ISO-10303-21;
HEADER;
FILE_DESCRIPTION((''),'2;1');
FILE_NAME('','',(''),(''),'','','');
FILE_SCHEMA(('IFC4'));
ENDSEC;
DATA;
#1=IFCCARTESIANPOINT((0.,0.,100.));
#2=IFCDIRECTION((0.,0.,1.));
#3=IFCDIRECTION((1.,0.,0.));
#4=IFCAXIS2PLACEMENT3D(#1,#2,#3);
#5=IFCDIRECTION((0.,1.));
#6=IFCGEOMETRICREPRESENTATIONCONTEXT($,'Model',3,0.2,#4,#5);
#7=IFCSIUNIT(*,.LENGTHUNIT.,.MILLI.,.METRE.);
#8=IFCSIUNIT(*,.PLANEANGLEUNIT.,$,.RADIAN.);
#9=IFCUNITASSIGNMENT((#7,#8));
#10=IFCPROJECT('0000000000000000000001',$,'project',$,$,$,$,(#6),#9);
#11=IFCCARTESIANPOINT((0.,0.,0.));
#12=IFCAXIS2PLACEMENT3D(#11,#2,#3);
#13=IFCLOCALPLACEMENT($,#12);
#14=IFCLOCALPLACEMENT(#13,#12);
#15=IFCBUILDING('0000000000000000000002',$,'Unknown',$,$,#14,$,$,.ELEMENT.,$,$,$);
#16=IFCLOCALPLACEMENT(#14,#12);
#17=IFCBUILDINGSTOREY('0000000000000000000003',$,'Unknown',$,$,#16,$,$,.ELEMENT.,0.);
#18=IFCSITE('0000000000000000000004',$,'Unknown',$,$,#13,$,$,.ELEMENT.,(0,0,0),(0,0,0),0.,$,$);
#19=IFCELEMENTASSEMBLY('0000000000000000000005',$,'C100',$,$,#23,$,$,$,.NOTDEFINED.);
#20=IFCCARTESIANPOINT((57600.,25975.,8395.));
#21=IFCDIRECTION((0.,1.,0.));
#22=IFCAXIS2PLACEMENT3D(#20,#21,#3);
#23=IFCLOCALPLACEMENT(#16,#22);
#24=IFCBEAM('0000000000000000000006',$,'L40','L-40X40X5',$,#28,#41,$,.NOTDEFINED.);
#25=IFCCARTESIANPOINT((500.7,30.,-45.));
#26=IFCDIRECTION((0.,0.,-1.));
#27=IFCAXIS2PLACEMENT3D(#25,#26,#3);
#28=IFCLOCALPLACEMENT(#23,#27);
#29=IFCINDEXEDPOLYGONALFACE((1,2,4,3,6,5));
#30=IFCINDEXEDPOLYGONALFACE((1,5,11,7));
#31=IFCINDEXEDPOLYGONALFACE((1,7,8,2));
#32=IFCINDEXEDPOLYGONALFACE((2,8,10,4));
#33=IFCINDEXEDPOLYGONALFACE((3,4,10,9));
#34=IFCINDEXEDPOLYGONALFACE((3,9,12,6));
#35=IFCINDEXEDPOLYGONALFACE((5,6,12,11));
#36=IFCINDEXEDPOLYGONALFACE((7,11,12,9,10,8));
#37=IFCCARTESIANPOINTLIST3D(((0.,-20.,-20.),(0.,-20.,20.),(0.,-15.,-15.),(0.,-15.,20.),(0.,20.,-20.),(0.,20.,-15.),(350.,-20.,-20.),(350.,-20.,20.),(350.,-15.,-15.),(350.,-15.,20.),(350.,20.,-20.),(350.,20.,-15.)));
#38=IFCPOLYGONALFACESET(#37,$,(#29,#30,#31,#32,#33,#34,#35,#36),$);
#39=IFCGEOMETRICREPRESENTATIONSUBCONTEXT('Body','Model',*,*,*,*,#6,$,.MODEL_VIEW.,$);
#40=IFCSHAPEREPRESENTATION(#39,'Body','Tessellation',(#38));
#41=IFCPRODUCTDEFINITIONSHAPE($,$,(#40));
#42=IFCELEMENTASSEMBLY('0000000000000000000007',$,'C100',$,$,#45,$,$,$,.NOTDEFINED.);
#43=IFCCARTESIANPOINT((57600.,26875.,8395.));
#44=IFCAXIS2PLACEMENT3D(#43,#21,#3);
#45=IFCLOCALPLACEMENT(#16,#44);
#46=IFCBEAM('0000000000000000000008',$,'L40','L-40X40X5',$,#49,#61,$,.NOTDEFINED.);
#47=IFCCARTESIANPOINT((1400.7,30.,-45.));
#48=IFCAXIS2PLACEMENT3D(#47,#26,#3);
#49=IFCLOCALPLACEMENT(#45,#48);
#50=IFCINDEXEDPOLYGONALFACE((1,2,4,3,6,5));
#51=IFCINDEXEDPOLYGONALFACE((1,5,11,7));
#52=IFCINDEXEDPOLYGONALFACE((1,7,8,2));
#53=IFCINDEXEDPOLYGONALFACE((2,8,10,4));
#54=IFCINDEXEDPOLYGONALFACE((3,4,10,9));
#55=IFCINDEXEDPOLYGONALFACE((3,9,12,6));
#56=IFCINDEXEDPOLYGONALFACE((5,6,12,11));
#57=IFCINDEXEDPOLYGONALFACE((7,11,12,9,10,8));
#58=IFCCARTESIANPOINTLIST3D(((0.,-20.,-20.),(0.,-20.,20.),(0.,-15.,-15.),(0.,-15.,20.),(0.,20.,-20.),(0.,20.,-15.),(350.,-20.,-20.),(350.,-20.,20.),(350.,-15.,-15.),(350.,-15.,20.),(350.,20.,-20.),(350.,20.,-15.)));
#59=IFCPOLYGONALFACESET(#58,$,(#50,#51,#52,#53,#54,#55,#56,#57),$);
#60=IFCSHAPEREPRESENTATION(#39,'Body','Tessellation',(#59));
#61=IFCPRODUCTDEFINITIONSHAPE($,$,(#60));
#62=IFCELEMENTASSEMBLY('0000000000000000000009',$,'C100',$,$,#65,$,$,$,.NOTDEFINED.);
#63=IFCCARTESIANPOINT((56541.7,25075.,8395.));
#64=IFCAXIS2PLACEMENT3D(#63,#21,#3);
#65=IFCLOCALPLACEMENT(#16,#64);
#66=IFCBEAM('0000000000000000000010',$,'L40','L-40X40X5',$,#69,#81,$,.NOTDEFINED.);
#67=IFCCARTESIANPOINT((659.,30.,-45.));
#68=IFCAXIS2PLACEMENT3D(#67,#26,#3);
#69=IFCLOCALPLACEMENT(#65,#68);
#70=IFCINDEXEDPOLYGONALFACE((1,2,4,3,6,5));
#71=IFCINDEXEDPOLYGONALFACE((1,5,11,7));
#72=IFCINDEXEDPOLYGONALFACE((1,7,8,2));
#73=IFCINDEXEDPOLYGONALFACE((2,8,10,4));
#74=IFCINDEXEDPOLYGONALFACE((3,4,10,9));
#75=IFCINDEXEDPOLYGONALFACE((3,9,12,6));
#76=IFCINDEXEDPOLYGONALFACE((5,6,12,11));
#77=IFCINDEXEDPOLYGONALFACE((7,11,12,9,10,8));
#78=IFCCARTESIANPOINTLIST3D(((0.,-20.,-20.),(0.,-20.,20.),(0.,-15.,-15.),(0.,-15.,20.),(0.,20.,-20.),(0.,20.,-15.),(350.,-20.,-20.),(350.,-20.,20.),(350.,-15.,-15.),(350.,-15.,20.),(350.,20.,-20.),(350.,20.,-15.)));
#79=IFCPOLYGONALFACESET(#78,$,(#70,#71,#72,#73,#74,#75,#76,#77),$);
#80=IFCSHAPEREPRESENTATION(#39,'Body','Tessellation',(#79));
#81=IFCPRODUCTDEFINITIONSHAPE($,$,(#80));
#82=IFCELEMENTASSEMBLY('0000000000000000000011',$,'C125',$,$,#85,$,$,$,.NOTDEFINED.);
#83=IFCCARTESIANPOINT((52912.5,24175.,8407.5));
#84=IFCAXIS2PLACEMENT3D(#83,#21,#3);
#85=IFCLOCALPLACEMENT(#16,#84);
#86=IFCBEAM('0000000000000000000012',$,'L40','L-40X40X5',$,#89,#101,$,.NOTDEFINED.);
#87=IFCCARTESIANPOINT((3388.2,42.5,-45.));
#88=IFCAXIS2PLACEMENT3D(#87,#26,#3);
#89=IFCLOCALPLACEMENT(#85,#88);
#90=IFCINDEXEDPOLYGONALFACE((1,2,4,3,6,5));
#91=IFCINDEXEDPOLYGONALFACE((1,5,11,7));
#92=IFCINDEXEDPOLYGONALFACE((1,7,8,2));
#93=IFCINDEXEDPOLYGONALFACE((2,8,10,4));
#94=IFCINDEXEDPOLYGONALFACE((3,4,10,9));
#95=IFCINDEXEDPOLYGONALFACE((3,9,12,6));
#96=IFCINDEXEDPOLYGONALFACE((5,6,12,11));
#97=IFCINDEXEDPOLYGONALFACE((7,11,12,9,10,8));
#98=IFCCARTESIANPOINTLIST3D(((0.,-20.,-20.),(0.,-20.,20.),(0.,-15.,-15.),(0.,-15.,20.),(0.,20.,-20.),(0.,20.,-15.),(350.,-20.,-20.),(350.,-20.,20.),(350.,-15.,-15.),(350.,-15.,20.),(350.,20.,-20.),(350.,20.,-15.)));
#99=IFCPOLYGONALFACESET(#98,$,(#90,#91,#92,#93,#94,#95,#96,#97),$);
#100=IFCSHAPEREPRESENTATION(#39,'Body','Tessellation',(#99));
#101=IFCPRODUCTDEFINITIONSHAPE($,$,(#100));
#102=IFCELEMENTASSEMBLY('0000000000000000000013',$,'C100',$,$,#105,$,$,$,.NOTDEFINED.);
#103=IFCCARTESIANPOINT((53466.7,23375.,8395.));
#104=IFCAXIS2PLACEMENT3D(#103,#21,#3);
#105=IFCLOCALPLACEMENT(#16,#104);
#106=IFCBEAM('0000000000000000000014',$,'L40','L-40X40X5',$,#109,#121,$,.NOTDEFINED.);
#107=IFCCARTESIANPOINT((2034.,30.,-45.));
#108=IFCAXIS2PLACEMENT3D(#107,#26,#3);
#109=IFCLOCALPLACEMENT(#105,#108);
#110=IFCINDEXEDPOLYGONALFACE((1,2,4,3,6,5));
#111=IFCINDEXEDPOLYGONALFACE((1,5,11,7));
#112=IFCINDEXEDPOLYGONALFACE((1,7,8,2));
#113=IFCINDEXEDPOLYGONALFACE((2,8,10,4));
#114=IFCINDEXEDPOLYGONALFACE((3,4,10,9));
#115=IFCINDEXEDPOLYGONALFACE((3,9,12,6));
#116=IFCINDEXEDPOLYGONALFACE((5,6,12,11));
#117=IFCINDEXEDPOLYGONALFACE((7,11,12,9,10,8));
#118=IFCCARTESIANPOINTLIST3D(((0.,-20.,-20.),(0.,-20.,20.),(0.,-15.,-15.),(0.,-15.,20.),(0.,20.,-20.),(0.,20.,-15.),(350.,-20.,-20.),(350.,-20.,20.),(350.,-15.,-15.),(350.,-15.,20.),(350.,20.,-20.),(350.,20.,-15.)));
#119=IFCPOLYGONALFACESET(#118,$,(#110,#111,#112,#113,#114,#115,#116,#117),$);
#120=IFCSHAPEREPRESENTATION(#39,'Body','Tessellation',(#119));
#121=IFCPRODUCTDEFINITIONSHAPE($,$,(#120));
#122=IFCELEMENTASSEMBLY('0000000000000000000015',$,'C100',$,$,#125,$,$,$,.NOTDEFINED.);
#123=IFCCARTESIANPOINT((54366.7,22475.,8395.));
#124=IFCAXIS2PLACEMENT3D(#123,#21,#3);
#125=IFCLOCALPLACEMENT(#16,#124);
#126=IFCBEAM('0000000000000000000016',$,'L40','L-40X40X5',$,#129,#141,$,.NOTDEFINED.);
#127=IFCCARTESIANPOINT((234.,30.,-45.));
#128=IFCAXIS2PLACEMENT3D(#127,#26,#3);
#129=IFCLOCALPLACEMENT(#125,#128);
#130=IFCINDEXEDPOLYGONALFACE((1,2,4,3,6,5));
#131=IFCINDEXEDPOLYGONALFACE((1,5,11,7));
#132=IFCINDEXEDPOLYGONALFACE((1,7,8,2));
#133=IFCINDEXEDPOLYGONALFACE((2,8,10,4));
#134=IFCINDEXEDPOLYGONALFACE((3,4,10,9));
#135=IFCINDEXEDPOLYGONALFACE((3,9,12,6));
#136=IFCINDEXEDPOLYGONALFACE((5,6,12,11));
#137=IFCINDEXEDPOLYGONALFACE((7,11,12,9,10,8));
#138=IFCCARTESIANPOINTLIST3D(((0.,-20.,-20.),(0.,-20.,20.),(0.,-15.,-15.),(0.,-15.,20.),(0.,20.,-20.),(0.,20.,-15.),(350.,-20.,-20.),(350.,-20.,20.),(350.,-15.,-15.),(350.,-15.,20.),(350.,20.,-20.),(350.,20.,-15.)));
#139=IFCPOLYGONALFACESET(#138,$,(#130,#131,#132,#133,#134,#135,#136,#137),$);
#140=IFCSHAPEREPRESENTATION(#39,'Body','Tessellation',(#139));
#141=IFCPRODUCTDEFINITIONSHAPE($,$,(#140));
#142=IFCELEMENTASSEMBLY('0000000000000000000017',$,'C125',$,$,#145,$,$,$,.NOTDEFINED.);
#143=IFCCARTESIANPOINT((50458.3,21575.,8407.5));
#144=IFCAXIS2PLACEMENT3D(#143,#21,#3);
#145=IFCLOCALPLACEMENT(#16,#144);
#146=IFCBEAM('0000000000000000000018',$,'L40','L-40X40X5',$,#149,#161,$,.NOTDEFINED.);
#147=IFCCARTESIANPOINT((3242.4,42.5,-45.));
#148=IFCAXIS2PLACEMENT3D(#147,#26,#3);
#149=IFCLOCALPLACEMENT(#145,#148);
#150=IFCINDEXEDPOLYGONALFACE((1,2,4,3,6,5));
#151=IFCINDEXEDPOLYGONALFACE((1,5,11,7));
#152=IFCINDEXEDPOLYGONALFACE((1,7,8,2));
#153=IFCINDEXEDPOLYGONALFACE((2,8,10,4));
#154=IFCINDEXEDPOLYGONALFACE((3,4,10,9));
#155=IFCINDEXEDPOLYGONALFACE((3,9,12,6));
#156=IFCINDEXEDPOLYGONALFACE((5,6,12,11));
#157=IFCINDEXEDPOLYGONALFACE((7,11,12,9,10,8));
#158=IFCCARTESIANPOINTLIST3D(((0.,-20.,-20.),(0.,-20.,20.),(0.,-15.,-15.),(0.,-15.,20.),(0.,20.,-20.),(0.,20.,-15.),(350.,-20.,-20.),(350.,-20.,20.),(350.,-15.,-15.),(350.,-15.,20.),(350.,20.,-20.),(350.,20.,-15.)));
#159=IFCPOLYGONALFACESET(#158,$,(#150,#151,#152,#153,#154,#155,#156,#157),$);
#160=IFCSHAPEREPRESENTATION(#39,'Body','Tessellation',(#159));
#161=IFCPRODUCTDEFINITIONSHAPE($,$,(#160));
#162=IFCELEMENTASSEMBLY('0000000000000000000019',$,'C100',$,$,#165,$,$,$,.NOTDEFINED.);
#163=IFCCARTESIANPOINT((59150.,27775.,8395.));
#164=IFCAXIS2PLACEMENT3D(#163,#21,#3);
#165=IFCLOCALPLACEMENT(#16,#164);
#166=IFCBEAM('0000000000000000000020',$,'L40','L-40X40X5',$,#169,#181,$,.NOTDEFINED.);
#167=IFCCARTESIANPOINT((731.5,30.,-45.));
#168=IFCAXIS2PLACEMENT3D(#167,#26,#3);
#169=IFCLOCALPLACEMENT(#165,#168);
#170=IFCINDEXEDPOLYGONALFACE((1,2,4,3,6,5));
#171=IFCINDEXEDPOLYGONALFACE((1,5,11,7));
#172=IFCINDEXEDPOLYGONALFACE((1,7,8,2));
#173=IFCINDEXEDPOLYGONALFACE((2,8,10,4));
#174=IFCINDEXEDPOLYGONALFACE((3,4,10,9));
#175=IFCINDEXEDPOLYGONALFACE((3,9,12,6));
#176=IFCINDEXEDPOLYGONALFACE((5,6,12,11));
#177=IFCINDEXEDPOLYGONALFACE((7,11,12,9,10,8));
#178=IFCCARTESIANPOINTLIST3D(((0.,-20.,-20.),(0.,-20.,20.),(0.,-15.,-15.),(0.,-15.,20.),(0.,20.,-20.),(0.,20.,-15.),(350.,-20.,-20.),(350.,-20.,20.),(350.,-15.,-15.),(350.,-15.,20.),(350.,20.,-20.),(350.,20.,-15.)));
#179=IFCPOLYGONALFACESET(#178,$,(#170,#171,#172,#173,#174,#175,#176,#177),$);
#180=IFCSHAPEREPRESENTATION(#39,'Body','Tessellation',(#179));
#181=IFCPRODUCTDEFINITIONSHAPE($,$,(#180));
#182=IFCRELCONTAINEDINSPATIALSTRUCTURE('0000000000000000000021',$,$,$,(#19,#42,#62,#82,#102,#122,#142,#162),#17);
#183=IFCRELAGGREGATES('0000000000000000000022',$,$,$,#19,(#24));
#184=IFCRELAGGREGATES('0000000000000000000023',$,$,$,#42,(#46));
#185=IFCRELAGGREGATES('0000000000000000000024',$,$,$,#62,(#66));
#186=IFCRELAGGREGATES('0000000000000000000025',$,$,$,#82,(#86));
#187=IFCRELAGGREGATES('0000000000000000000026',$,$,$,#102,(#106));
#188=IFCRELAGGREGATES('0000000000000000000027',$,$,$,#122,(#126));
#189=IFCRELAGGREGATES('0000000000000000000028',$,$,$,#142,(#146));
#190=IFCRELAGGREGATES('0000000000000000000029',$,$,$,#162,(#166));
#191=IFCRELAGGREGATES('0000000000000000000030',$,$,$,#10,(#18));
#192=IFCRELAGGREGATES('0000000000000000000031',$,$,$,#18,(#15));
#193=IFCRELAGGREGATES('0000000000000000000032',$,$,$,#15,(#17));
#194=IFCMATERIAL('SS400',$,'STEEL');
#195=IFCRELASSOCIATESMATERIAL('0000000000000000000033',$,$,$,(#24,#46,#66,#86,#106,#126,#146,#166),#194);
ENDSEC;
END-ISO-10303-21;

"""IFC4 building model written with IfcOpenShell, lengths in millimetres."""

from ifc_helpers import new_model, si_unit, direction, frame, origin_with_axes, place, context, subcontext, project, spatial, line, indexed_curve, outline, extrude, material, element, aggregate, save


model = new_model("IFC4")

# Units and contexts
model_context = context("Model", 3, precision=0.2, world=frame((0.0, 0.0, 100.0), z_axis=(0.0, 0.0, 1.0), x_axis=(1.0, 0.0, 0.0)), true_north=direction((0.0, 1.0)))
body_context = subcontext(model_context, "Body", "Model", "MODEL_VIEW")
ifc_project = project(units=[si_unit("LENGTHUNIT", "METRE", prefix="MILLI"), si_unit("PLANEANGLEUNIT", "RADIAN")], contexts=[model_context])

# Site, building, storey
site_placement = place(None, origin_with_axes())
site = spatial("IfcSite", under=ifc_project, at=site_placement, Name="Unknown", CompositionType="ELEMENT", RefLatitude=(0, 0, 0), RefLongitude=(0, 0, 0), RefElevation=0.0)
building_placement = place(site_placement, origin_with_axes())
building = spatial("IfcBuilding", under=site, at=building_placement, Name="Unknown", CompositionType="ELEMENT")
storey_placement = place(building_placement, origin_with_axes())
storey = spatial("IfcBuildingStorey", under=building, at=storey_placement, Name="Unknown", CompositionType="ELEMENT", Elevation=0.0)

# Element assemblies, beams
assembly_1_placement = place(storey_placement, frame((57600.0, 25975.0, 8395.0), z_axis=(0.0, 1.0, 0.0), x_axis=(1.0, 0.0, 0.0)))
assembly_1 = element("IfcElementAssembly", 1, at=assembly_1_placement, inside=storey, Name="C100", PredefinedType="NOTDEFINED")
ifc_material_1 = material(Name="SS400", Category="STEEL")
beam_1_placement = place(assembly_1_placement, frame((500.7, 30.0, -45.0), z_axis=(0.0, 0.0, -1.0), x_axis=(1.0, 0.0, 0.0)))
beam_1 = element("IfcBeam", 2, at=beam_1_placement, material=ifc_material_1, Name="L40", Description="L-40X40X5", PredefinedType="NOTDEFINED", context=body_context, shape_type="SolidModel", body=[
    extrude(outline(indexed_curve([(-20.0, -20.0), (20.0, -20.0), (20.0, -15.0), (-15.0, -15.0), (-15.0, 20.0), (-20.0, 20.0)], segments=[line(1, 2, 3, 4, 5, 6, 1)])), frame((0.0, 0.0, 0.0), z_axis=(-1.0, 0.0, 0.0), x_axis=(0.0, 0.0, 1.0)), (0.0, 0.0, -1.0), 350.0),
])
aggregate(assembly_1, [beam_1])
assembly_2_placement = place(storey_placement, frame((57600.0, 26875.0, 8395.0), z_axis=(0.0, 1.0, 0.0), x_axis=(1.0, 0.0, 0.0)))
assembly_2 = element("IfcElementAssembly", 3, at=assembly_2_placement, inside=storey, Name="C100", PredefinedType="NOTDEFINED")
beam_2_placement = place(assembly_2_placement, frame((1400.7, 30.0, -45.0), z_axis=(0.0, 0.0, -1.0), x_axis=(1.0, 0.0, 0.0)))
beam_2 = element("IfcBeam", 4, at=beam_2_placement, material=ifc_material_1, Name="L40", Description="L-40X40X5", PredefinedType="NOTDEFINED", context=body_context, shape_type="SolidModel", body=[
    extrude(outline(indexed_curve([(-20.0, -20.0), (20.0, -20.0), (20.0, -15.0), (-15.0, -15.0), (-15.0, 20.0), (-20.0, 20.0)], segments=[line(1, 2, 3, 4, 5, 6, 1)])), frame((0.0, 0.0, 0.0), z_axis=(-1.0, 0.0, 0.0), x_axis=(0.0, 0.0, 1.0)), (0.0, 0.0, -1.0), 350.0),
])
aggregate(assembly_2, [beam_2])
assembly_3_placement = place(storey_placement, frame((56541.7, 25075.0, 8395.0), z_axis=(0.0, 1.0, 0.0), x_axis=(1.0, 0.0, 0.0)))
assembly_3 = element("IfcElementAssembly", 5, at=assembly_3_placement, inside=storey, Name="C100", PredefinedType="NOTDEFINED")
beam_3_placement = place(assembly_3_placement, frame((659.0, 30.0, -45.0), z_axis=(0.0, 0.0, -1.0), x_axis=(1.0, 0.0, 0.0)))
beam_3 = element("IfcBeam", 6, at=beam_3_placement, material=ifc_material_1, Name="L40", Description="L-40X40X5", PredefinedType="NOTDEFINED", context=body_context, shape_type="SolidModel", body=[
    extrude(outline(indexed_curve([(-20.0, -20.0), (20.0, -20.0), (20.0, -15.0), (-15.0, -15.0), (-15.0, 20.0), (-20.0, 20.0)], segments=[line(1, 2, 3, 4, 5, 6, 1)])), frame((0.0, 0.0, 0.0), z_axis=(-1.0, 0.0, 0.0), x_axis=(0.0, 0.0, 1.0)), (0.0, 0.0, -1.0), 350.0),
])
aggregate(assembly_3, [beam_3])
assembly_4_placement = place(storey_placement, frame((52912.5, 24175.0, 8407.5), z_axis=(0.0, 1.0, 0.0), x_axis=(1.0, 0.0, 0.0)))
assembly_4 = element("IfcElementAssembly", 7, at=assembly_4_placement, inside=storey, Name="C125", PredefinedType="NOTDEFINED")
beam_4_placement = place(assembly_4_placement, frame((3388.2, 42.5, -45.0), z_axis=(0.0, 0.0, -1.0), x_axis=(1.0, 0.0, 0.0)))
beam_4 = element("IfcBeam", 8, at=beam_4_placement, material=ifc_material_1, Name="L40", Description="L-40X40X5", PredefinedType="NOTDEFINED", context=body_context, shape_type="SolidModel", body=[
    extrude(outline(indexed_curve([(-20.0, -20.0), (20.0, -20.0), (20.0, -15.0), (-15.0, -15.0), (-15.0, 20.0), (-20.0, 20.0)], segments=[line(1, 2, 3, 4, 5, 6, 1)])), frame((0.0, 0.0, 0.0), z_axis=(-1.0, 0.0, 0.0), x_axis=(0.0, 0.0, 1.0)), (0.0, 0.0, -1.0), 350.0),
])
aggregate(assembly_4, [beam_4])
assembly_5_placement = place(storey_placement, frame((53466.7, 23375.0, 8395.0), z_axis=(0.0, 1.0, 0.0), x_axis=(1.0, 0.0, 0.0)))
assembly_5 = element("IfcElementAssembly", 9, at=assembly_5_placement, inside=storey, Name="C100", PredefinedType="NOTDEFINED")
beam_5_placement = place(assembly_5_placement, frame((2034.0, 30.0, -45.0), z_axis=(0.0, 0.0, -1.0), x_axis=(1.0, 0.0, 0.0)))
beam_5 = element("IfcBeam", 10, at=beam_5_placement, material=ifc_material_1, Name="L40", Description="L-40X40X5", PredefinedType="NOTDEFINED", context=body_context, shape_type="SolidModel", body=[
    extrude(outline(indexed_curve([(-20.0, -20.0), (20.0, -20.0), (20.0, -15.0), (-15.0, -15.0), (-15.0, 20.0), (-20.0, 20.0)], segments=[line(1, 2, 3, 4, 5, 6, 1)])), frame((0.0, 0.0, 0.0), z_axis=(-1.0, 0.0, 0.0), x_axis=(0.0, 0.0, 1.0)), (0.0, 0.0, -1.0), 350.0),
])
aggregate(assembly_5, [beam_5])
assembly_6_placement = place(storey_placement, frame((54366.7, 22475.0, 8395.0), z_axis=(0.0, 1.0, 0.0), x_axis=(1.0, 0.0, 0.0)))
assembly_6 = element("IfcElementAssembly", 11, at=assembly_6_placement, inside=storey, Name="C100", PredefinedType="NOTDEFINED")
beam_6_placement = place(assembly_6_placement, frame((234.0, 30.0, -45.0), z_axis=(0.0, 0.0, -1.0), x_axis=(1.0, 0.0, 0.0)))
beam_6 = element("IfcBeam", 12, at=beam_6_placement, material=ifc_material_1, Name="L40", Description="L-40X40X5", PredefinedType="NOTDEFINED", context=body_context, shape_type="SolidModel", body=[
    extrude(outline(indexed_curve([(-20.0, -20.0), (20.0, -20.0), (20.0, -15.0), (-15.0, -15.0), (-15.0, 20.0), (-20.0, 20.0)], segments=[line(1, 2, 3, 4, 5, 6, 1)])), frame((0.0, 0.0, 0.0), z_axis=(-1.0, 0.0, 0.0), x_axis=(0.0, 0.0, 1.0)), (0.0, 0.0, -1.0), 350.0),
])
aggregate(assembly_6, [beam_6])
assembly_7_placement = place(storey_placement, frame((50458.3, 21575.0, 8407.5), z_axis=(0.0, 1.0, 0.0), x_axis=(1.0, 0.0, 0.0)))
assembly_7 = element("IfcElementAssembly", 13, at=assembly_7_placement, inside=storey, Name="C125", PredefinedType="NOTDEFINED")
beam_7_placement = place(assembly_7_placement, frame((3242.4, 42.5, -45.0), z_axis=(0.0, 0.0, -1.0), x_axis=(1.0, 0.0, 0.0)))
beam_7 = element("IfcBeam", 14, at=beam_7_placement, material=ifc_material_1, Name="L40", Description="L-40X40X5", PredefinedType="NOTDEFINED", context=body_context, shape_type="SolidModel", body=[
    extrude(outline(indexed_curve([(-20.0, -20.0), (20.0, -20.0), (20.0, -15.0), (-15.0, -15.0), (-15.0, 20.0), (-20.0, 20.0)], segments=[line(1, 2, 3, 4, 5, 6, 1)])), frame((0.0, 0.0, 0.0), z_axis=(-1.0, 0.0, 0.0), x_axis=(0.0, 0.0, 1.0)), (0.0, 0.0, -1.0), 350.0),
])
aggregate(assembly_7, [beam_7])
assembly_8_placement = place(storey_placement, frame((59150.0, 27775.0, 8395.0), z_axis=(0.0, 1.0, 0.0), x_axis=(1.0, 0.0, 0.0)))
assembly_8 = element("IfcElementAssembly", 15, at=assembly_8_placement, inside=storey, Name="C100", PredefinedType="NOTDEFINED")
beam_8_placement = place(assembly_8_placement, frame((731.5, 30.0, -45.0), z_axis=(0.0, 0.0, -1.0), x_axis=(1.0, 0.0, 0.0)))
beam_8 = element("IfcBeam", 16, at=beam_8_placement, material=ifc_material_1, Name="L40", Description="L-40X40X5", PredefinedType="NOTDEFINED", context=body_context, shape_type="SolidModel", body=[
    extrude(outline(indexed_curve([(-20.0, -20.0), (20.0, -20.0), (20.0, -15.0), (-15.0, -15.0), (-15.0, 20.0), (-20.0, 20.0)], segments=[line(1, 2, 3, 4, 5, 6, 1)])), frame((0.0, 0.0, 0.0), z_axis=(-1.0, 0.0, 0.0), x_axis=(0.0, 0.0, 1.0)), (0.0, 0.0, -1.0), 350.0),
])
aggregate(assembly_8, [beam_8])

save(model, "model.ifc")
